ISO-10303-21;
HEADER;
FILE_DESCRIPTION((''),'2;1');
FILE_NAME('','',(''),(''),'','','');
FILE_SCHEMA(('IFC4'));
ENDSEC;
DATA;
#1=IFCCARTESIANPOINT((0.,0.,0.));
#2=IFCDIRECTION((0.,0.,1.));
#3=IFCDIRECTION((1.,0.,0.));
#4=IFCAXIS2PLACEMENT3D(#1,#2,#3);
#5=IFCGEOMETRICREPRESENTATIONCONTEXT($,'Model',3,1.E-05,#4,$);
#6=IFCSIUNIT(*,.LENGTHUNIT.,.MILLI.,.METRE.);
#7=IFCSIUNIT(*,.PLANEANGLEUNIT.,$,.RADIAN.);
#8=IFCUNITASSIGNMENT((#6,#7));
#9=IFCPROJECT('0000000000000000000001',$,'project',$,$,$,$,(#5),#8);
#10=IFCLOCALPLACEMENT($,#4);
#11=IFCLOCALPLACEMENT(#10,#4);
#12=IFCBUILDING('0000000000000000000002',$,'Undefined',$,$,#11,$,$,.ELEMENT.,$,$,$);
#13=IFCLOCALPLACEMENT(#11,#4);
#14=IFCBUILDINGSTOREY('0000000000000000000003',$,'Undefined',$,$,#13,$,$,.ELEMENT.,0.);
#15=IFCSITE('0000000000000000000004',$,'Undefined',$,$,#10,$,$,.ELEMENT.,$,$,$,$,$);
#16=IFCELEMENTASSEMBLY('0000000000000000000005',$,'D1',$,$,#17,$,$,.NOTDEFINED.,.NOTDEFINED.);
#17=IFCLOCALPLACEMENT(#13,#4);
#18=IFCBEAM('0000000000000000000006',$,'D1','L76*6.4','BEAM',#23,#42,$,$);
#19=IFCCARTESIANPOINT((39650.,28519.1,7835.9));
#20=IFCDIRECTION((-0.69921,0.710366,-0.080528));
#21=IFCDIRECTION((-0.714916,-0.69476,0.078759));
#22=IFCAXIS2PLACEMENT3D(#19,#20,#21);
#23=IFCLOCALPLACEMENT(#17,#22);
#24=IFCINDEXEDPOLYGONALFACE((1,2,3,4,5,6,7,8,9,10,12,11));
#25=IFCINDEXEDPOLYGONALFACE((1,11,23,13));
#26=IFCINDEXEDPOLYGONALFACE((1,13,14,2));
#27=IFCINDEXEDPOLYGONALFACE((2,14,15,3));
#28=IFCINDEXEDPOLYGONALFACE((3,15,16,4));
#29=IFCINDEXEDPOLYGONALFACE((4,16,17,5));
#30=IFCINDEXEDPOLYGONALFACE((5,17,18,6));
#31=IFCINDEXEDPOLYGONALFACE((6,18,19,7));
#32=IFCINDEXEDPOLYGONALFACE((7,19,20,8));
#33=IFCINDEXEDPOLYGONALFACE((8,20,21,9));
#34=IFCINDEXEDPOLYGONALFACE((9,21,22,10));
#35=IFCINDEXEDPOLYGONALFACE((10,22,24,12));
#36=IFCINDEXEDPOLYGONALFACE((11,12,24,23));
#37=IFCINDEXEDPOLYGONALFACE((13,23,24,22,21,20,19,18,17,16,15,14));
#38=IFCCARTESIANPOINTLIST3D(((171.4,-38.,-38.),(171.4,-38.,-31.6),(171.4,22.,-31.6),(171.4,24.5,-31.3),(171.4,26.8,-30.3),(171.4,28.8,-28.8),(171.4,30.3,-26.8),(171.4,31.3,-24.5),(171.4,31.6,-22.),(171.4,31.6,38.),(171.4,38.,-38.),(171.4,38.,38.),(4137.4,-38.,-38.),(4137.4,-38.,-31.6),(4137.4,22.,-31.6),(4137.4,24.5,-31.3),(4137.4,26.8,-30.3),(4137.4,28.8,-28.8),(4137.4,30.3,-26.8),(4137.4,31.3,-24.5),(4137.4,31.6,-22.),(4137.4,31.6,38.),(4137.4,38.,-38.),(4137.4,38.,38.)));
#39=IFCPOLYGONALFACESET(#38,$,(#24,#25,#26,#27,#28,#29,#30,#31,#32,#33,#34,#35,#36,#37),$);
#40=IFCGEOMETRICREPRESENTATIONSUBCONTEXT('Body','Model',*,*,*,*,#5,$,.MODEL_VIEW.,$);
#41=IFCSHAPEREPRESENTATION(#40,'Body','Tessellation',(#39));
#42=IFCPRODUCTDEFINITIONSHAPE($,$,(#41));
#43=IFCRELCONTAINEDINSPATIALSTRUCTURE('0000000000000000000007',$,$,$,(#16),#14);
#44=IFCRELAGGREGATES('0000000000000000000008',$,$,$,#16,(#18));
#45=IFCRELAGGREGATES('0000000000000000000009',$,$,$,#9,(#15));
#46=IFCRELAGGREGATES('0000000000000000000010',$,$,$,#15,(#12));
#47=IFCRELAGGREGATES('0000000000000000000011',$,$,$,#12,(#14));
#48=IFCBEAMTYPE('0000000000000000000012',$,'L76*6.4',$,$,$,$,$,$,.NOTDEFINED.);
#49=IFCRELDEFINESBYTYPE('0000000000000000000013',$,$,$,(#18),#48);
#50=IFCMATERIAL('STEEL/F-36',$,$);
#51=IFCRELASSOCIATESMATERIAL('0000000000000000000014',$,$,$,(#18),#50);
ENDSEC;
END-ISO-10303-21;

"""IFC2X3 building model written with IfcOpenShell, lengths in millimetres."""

from ifc_helpers import new_model, si_unit, frame, origin_with_axes, origin_2d_with_axis, place, context, subcontext, project, spatial, l_section, extrude, clip, halfspace, material, type_object, element, aggregate, save


model = new_model("IFC2X3")

# Units and contexts
model_context = context("Model", 3, precision=1e-05, world=origin_with_axes())
body_context = subcontext(model_context, "Body", "Model", "MODEL_VIEW")
ifc_project = project(units=[si_unit("LENGTHUNIT", "METRE", prefix="MILLI"), si_unit("PLANEANGLEUNIT", "RADIAN")], contexts=[model_context])

# Site, building, storey
site_placement = place(None, origin_with_axes())
site = spatial("IfcSite", under=ifc_project, at=site_placement, Name="Undefined", CompositionType="ELEMENT")
building_placement = place(site_placement, origin_with_axes())
building = spatial("IfcBuilding", under=site, at=building_placement, Name="Undefined", CompositionType="ELEMENT")
storey_placement = place(building_placement, origin_with_axes())
storey = spatial("IfcBuildingStorey", under=building, at=storey_placement, Name="Undefined", CompositionType="ELEMENT", Elevation=0.0)

# Element assembly, beam
assembly_1_placement = place(storey_placement, origin_with_axes())
assembly_1 = element("IfcElementAssembly", 1, at=assembly_1_placement, inside=storey, Name="D1", AssemblyPlace="NOTDEFINED", PredefinedType="NOTDEFINED")
ifc_material_1 = material(Name="STEEL/F-36")
beam_type = type_object("IfcBeamType", Name="L76*6.4", PredefinedType="NOTDEFINED")
beam_placement = place(assembly_1_placement, frame((39650.0, 28519.1, 7835.9), z_axis=(-0.69921, 0.710366, -0.080528), x_axis=(-0.714916, -0.69476, 0.078759)))
beam = element("IfcBeam", 2, at=beam_placement, type_object=beam_type, material=ifc_material_1, Name="D1", Description="L76*6.4", ObjectType="BEAM", context=body_context, shape_type="Clipping", body=[
    clip(clip(extrude(l_section(Depth=76.0, Width=76.0, Thickness=6.4, FilletRadius=9.6, at=origin_2d_with_axis()), frame((4225.7, 0.0, 0.0), z_axis=(-1.0, 0.0, 0.0), x_axis=(0.0, -1.0, 0.0)), (0.0, 0.0, 1.0), 4225.8), halfspace(frame((4137.4, 44.4, 0.0), z_axis=(-1.0, 0.0, 0.0), x_axis=(0.0, 0.0, -1.0)), True)), halfspace(frame((171.4, 44.4, 0.0), z_axis=(1.0, 0.0, 0.0), x_axis=(0.0, -0.000018, 1.0)), True)),
])
aggregate(assembly_1, [beam])

save(model, "model.ifc")
